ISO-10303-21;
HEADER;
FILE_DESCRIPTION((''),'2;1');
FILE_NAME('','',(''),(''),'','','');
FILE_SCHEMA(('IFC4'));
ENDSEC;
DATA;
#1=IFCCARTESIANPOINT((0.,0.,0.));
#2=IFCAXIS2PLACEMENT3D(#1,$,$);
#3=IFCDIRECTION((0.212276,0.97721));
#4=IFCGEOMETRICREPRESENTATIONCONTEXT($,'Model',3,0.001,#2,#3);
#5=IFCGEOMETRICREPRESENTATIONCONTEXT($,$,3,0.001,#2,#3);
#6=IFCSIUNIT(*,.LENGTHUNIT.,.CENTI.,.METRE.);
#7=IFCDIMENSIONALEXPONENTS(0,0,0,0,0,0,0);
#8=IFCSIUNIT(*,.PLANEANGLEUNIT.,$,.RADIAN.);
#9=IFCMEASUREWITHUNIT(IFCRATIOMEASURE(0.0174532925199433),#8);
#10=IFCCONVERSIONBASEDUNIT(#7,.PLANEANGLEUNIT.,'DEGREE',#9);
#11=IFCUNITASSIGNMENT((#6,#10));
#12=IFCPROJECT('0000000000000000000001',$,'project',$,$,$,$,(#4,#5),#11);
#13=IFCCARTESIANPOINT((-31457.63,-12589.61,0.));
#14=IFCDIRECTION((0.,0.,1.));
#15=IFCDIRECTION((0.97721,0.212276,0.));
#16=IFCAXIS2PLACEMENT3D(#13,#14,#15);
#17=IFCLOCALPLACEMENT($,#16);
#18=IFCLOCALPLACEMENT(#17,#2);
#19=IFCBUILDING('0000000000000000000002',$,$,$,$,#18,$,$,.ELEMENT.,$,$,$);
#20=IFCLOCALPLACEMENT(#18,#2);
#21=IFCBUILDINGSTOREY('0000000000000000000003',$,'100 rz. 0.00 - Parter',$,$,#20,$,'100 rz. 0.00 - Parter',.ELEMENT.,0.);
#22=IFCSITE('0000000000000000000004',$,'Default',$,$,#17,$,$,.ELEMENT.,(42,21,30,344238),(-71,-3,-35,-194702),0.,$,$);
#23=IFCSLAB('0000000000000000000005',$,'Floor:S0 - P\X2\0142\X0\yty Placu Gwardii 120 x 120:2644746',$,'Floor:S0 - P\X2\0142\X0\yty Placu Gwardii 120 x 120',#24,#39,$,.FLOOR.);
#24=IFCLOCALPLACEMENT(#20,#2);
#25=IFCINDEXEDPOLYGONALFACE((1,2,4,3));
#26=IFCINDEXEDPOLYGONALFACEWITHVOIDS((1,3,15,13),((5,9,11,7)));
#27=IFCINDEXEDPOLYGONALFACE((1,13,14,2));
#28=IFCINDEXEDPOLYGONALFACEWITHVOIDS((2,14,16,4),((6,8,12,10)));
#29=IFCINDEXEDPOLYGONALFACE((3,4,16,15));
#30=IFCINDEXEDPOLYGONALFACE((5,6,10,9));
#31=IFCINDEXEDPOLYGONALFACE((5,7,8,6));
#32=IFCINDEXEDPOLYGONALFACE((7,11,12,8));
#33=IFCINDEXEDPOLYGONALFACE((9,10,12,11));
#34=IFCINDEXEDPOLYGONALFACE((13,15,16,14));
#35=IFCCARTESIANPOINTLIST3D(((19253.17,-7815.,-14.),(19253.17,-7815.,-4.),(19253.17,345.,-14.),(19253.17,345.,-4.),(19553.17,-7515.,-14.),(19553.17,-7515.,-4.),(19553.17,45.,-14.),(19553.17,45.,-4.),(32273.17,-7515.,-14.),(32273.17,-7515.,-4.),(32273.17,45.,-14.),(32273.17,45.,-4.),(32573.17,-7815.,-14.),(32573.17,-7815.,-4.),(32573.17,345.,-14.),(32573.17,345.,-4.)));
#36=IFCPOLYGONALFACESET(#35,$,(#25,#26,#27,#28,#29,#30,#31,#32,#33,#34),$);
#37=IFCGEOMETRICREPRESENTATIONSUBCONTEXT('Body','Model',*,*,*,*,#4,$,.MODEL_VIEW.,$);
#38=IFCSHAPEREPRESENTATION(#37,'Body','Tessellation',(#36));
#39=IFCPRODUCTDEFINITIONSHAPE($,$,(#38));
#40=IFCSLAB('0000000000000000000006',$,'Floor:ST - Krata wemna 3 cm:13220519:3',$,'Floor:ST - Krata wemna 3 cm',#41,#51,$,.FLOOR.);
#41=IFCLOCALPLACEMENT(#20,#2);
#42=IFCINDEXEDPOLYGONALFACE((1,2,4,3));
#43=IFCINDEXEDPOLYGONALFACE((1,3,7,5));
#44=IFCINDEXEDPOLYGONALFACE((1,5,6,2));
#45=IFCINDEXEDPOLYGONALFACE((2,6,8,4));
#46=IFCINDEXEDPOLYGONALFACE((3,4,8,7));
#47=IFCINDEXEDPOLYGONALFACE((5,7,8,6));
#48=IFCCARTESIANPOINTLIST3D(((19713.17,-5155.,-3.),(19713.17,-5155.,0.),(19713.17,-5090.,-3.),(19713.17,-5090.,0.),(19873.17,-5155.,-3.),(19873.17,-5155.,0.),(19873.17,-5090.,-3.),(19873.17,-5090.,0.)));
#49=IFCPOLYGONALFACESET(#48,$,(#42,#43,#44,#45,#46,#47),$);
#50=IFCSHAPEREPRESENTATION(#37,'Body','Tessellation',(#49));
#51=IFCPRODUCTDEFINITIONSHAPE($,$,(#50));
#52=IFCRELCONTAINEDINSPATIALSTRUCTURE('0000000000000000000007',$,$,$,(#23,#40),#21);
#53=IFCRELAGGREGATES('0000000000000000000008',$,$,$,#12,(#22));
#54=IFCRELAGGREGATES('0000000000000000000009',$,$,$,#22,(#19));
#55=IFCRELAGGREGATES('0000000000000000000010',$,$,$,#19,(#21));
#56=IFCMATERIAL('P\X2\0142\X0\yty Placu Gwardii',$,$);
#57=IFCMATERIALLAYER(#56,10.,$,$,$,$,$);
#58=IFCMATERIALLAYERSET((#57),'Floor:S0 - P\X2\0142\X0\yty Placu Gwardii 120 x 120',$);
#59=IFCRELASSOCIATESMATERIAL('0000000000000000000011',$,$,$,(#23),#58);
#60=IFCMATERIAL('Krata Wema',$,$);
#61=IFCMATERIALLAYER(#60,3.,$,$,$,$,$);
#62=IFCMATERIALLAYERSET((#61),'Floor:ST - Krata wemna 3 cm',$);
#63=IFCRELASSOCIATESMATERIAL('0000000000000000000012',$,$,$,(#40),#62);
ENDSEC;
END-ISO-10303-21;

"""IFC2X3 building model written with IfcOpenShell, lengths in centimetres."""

from ifc_helpers import new_model, entity, si_unit, converted_unit, direction, frame, frame_2d, origin, origin_2d_with_axis, place, context, subcontext, project, spatial, rectangle, extrude, material, layer, layer_set, layer_usage, element, save


model = new_model("IFC2X3")

# Units and contexts
model_context = context("Model", 3, precision=0.001, world=origin(), true_north=direction((0.212276, 0.97721)))
context_of_model = context(None, 3, precision=0.001, world=origin(), true_north=direction((0.212276, 0.97721)))
body_context = subcontext(model_context, "Body", "Model", "MODEL_VIEW")
ifc_project = project(units=[si_unit("LENGTHUNIT", "METRE", prefix="CENTI"), converted_unit("PLANEANGLEUNIT", "DEGREE", entity("IfcRatioMeasure", 0.0174532925199433), si_unit("PLANEANGLEUNIT", "RADIAN"), dimensions=[0, 0, 0, 0, 0, 0, 0])], contexts=[model_context, context_of_model])

# Site, building, storey
site_placement = place(None, frame((-31457.63, -12589.61, 0.0), z_axis=(0.0, 0.0, 1.0), x_axis=(0.97721, 0.212276, 0.0)))
site = spatial("IfcSite", under=ifc_project, at=site_placement, Name="Default", CompositionType="ELEMENT", RefLatitude=(42, 21, 30, 344238), RefLongitude=(-71, -3, -35, -194702), RefElevation=0.0)
building_placement = place(site_placement, origin())
building = spatial("IfcBuilding", under=site, at=building_placement, CompositionType="ELEMENT")
storey_placement = place(building_placement, origin())
storey = spatial("IfcBuildingStorey", under=building, at=storey_placement, Name="100 rz. 0.00 - Parter", LongName="100 rz. 0.00 - Parter", CompositionType="ELEMENT", Elevation=0.0)

# Shared definitions
ifc_material_1 = material(Name="Płyty Placu Gwardii")
ifc_layer_1 = layer(ifc_material_1, 10.0)
ifc_layer_set_1 = layer_set([ifc_layer_1], Name="Floor:S0 - Płyty Placu Gwardii 120 x 120")

# Slab, opening
ifc_layer_usage_1 = layer_usage(ifc_layer_set_1, "AXIS3", "POSITIVE", 0.0)
slab_1_placement = place(storey_placement, frame((19253.17, -7815.0, -14.0)))
slab_1 = element("IfcSlab", 1, at=slab_1_placement, inside=storey, material=ifc_layer_usage_1, Name="Floor:S0 - Płyty Placu Gwardii 120 x 120:2644746", ObjectType="Floor:S0 - Płyty Placu Gwardii 120 x 120", PredefinedType="FLOOR", context=body_context, shape_type="SweptSolid", body=[
    extrude(rectangle(XDim=8160.0, YDim=13320.0, at=frame_2d((0.0, 0.0), x_axis=(0.0, 1.0))), frame((6660.0, 4080.0, 10.0), z_axis=(0.0, 0.0, -1.0), x_axis=(-1.0, 0.0, 0.0)), (0.0, 0.0, 1.0), 10.0),
])
opening_1_placement = place(slab_1_placement, frame((6660.0, 4080.0, 10.0)))
element("IfcOpeningElement", 2, at=opening_1_placement, cuts=slab_1, ObjectType="Opening", context=body_context, shape_type="SweptSolid", body=[
    extrude(rectangle(XDim=7560.0, YDim=12720.0, at=origin_2d_with_axis()), frame((0.0, 0.0, 0.0), z_axis=(0.0, 0.0, -1.0), x_axis=(0.0, -1.0, 0.0)), (0.0, 0.0, 1.0), 10.0),
])

# Slab
ifc_material_2 = material(Name="Krata Wema")
ifc_layer_2 = layer(ifc_material_2, 3.0)
ifc_layer_set_2 = layer_set([ifc_layer_2], Name="Floor:ST - Krata wemna 3 cm")
ifc_layer_usage_2 = layer_usage(ifc_layer_set_2, "AXIS3", "POSITIVE", 0.0)
slab_2_placement = place(storey_placement, frame((19713.17, -5155.0, -3.0)))
element("IfcSlab", 3, at=slab_2_placement, inside=storey, material=ifc_layer_usage_2, Name="Floor:ST - Krata wemna 3 cm:13220519:3", ObjectType="Floor:ST - Krata wemna 3 cm", PredefinedType="FLOOR", context=body_context, shape_type="SweptSolid", body=[
    extrude(rectangle(XDim=160.0, YDim=65.0, at=frame_2d((300.0, 0.0), x_axis=(-1.0, 0.0))), frame((380.0, 32.5, 3.0), z_axis=(0.0, 0.0, -1.0), x_axis=(-1.0, 0.0, 0.0)), (0.0, 0.0, 1.0), 3.0),
])

save(model, "model.ifc")
